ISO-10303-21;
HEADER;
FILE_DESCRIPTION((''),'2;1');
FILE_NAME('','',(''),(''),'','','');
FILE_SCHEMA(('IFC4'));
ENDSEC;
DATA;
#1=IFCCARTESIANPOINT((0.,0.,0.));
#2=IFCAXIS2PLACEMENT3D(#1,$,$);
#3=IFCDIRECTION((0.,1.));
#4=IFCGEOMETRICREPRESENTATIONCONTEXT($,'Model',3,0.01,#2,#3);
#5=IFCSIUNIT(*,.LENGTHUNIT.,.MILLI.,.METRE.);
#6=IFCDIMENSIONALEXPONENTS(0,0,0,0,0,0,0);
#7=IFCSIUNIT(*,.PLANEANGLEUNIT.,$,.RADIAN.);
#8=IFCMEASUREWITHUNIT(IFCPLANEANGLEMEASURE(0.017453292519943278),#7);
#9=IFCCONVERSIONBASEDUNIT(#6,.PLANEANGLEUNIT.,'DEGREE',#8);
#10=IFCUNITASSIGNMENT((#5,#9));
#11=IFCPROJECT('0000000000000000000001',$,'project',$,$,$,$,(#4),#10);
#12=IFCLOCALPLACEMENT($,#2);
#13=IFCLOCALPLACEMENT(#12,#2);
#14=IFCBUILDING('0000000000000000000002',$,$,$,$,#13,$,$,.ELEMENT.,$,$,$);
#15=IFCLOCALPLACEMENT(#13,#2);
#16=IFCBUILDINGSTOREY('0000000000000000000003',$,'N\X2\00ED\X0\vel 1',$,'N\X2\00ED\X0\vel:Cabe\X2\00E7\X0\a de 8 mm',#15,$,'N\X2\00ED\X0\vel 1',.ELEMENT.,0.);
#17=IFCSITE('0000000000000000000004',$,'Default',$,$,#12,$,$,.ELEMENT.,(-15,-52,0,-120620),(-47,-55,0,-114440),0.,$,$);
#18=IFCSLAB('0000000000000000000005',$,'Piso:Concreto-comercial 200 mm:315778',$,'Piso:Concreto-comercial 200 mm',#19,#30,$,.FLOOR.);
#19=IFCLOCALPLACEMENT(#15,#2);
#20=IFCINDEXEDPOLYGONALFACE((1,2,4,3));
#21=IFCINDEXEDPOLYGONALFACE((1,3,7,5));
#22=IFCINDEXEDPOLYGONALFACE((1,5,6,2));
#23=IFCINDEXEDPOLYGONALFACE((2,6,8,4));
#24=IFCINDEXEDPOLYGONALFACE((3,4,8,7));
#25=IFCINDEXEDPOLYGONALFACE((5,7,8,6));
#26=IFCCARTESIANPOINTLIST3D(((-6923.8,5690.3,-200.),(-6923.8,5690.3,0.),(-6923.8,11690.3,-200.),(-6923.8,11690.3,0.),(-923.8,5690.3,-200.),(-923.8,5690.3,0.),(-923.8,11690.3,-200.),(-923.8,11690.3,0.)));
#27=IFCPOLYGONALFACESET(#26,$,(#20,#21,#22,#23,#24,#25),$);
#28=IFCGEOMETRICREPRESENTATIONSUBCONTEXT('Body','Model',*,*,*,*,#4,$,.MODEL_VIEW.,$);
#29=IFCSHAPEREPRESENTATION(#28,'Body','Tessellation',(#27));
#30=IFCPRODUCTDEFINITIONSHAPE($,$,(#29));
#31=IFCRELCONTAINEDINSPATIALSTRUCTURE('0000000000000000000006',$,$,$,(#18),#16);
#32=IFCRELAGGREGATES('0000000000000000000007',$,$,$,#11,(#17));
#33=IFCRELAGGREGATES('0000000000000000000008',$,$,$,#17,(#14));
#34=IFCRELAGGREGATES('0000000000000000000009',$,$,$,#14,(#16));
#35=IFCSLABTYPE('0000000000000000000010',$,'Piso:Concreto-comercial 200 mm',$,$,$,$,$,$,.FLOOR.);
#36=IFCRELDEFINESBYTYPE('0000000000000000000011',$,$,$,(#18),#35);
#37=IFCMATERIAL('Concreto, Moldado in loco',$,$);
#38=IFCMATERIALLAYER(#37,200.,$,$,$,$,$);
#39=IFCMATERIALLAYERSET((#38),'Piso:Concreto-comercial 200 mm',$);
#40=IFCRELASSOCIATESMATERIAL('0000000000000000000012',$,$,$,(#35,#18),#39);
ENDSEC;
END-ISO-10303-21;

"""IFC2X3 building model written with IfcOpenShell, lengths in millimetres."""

from ifc_helpers import new_model, entity, si_unit, converted_unit, direction, frame, origin, origin_2d_with_axis, place, context, subcontext, project, spatial, rectangle, extrude, material, layer, layer_set, layer_usage, type_object, element, save


model = new_model("IFC2X3")

# Units and contexts
model_context = context("Model", 3, precision=0.01, world=origin(), true_north=direction((0.0, 1.0)))
body_context = subcontext(model_context, "Body", "Model", "MODEL_VIEW")
ifc_project = project(units=[si_unit("LENGTHUNIT", "METRE", prefix="MILLI"), converted_unit("PLANEANGLEUNIT", "DEGREE", entity("IfcPlaneAngleMeasure", 0.017453292519943278), si_unit("PLANEANGLEUNIT", "RADIAN"), dimensions=[0, 0, 0, 0, 0, 0, 0])], contexts=[model_context])

# Site, building, storey
site_placement = place(None, origin())
site = spatial("IfcSite", under=ifc_project, at=site_placement, Name="Default", CompositionType="ELEMENT", RefLatitude=(-15, -52, 0, -120620), RefLongitude=(-47, -55, 0, -114440), RefElevation=0.0)
building_placement = place(site_placement, origin())
building = spatial("IfcBuilding", under=site, at=building_placement, CompositionType="ELEMENT")
storey_placement = place(building_placement, origin())
storey = spatial("IfcBuildingStorey", under=building, at=storey_placement, Name="Nível 1", ObjectType="Nível:Cabeça de 8 mm", LongName="Nível 1", CompositionType="ELEMENT", Elevation=0.0)

# Slab
ifc_material_1 = material(Name="Concreto, Moldado in loco")
ifc_layer = layer(ifc_material_1, 200.0)
ifc_layer_set = layer_set([ifc_layer], Name="Piso:Concreto-comercial 200 mm")
ifc_layer_usage = layer_usage(ifc_layer_set, "AXIS3", "POSITIVE", 0.0)
slab_type = type_object("IfcSlabType", Name="Piso:Concreto-comercial 200 mm", PredefinedType="FLOOR", material=ifc_layer_set)
slab_placement = place(storey_placement, origin())
element("IfcSlab", 1, at=slab_placement, inside=storey, type_object=slab_type, material=ifc_layer_usage, Name="Piso:Concreto-comercial 200 mm:315778", ObjectType="Piso:Concreto-comercial 200 mm", PredefinedType="FLOOR", context=body_context, shape_type="SweptSolid", body=[
    extrude(rectangle(XDim=6000.0, YDim=6000.0, at=origin_2d_with_axis()), frame((-3923.8, 8690.3, 0.0), z_axis=(0.0, 0.0, -1.0), x_axis=(0.0, 1.0, 0.0)), (0.0, 0.0, 1.0), 200.0),
])

save(model, "model.ifc")
